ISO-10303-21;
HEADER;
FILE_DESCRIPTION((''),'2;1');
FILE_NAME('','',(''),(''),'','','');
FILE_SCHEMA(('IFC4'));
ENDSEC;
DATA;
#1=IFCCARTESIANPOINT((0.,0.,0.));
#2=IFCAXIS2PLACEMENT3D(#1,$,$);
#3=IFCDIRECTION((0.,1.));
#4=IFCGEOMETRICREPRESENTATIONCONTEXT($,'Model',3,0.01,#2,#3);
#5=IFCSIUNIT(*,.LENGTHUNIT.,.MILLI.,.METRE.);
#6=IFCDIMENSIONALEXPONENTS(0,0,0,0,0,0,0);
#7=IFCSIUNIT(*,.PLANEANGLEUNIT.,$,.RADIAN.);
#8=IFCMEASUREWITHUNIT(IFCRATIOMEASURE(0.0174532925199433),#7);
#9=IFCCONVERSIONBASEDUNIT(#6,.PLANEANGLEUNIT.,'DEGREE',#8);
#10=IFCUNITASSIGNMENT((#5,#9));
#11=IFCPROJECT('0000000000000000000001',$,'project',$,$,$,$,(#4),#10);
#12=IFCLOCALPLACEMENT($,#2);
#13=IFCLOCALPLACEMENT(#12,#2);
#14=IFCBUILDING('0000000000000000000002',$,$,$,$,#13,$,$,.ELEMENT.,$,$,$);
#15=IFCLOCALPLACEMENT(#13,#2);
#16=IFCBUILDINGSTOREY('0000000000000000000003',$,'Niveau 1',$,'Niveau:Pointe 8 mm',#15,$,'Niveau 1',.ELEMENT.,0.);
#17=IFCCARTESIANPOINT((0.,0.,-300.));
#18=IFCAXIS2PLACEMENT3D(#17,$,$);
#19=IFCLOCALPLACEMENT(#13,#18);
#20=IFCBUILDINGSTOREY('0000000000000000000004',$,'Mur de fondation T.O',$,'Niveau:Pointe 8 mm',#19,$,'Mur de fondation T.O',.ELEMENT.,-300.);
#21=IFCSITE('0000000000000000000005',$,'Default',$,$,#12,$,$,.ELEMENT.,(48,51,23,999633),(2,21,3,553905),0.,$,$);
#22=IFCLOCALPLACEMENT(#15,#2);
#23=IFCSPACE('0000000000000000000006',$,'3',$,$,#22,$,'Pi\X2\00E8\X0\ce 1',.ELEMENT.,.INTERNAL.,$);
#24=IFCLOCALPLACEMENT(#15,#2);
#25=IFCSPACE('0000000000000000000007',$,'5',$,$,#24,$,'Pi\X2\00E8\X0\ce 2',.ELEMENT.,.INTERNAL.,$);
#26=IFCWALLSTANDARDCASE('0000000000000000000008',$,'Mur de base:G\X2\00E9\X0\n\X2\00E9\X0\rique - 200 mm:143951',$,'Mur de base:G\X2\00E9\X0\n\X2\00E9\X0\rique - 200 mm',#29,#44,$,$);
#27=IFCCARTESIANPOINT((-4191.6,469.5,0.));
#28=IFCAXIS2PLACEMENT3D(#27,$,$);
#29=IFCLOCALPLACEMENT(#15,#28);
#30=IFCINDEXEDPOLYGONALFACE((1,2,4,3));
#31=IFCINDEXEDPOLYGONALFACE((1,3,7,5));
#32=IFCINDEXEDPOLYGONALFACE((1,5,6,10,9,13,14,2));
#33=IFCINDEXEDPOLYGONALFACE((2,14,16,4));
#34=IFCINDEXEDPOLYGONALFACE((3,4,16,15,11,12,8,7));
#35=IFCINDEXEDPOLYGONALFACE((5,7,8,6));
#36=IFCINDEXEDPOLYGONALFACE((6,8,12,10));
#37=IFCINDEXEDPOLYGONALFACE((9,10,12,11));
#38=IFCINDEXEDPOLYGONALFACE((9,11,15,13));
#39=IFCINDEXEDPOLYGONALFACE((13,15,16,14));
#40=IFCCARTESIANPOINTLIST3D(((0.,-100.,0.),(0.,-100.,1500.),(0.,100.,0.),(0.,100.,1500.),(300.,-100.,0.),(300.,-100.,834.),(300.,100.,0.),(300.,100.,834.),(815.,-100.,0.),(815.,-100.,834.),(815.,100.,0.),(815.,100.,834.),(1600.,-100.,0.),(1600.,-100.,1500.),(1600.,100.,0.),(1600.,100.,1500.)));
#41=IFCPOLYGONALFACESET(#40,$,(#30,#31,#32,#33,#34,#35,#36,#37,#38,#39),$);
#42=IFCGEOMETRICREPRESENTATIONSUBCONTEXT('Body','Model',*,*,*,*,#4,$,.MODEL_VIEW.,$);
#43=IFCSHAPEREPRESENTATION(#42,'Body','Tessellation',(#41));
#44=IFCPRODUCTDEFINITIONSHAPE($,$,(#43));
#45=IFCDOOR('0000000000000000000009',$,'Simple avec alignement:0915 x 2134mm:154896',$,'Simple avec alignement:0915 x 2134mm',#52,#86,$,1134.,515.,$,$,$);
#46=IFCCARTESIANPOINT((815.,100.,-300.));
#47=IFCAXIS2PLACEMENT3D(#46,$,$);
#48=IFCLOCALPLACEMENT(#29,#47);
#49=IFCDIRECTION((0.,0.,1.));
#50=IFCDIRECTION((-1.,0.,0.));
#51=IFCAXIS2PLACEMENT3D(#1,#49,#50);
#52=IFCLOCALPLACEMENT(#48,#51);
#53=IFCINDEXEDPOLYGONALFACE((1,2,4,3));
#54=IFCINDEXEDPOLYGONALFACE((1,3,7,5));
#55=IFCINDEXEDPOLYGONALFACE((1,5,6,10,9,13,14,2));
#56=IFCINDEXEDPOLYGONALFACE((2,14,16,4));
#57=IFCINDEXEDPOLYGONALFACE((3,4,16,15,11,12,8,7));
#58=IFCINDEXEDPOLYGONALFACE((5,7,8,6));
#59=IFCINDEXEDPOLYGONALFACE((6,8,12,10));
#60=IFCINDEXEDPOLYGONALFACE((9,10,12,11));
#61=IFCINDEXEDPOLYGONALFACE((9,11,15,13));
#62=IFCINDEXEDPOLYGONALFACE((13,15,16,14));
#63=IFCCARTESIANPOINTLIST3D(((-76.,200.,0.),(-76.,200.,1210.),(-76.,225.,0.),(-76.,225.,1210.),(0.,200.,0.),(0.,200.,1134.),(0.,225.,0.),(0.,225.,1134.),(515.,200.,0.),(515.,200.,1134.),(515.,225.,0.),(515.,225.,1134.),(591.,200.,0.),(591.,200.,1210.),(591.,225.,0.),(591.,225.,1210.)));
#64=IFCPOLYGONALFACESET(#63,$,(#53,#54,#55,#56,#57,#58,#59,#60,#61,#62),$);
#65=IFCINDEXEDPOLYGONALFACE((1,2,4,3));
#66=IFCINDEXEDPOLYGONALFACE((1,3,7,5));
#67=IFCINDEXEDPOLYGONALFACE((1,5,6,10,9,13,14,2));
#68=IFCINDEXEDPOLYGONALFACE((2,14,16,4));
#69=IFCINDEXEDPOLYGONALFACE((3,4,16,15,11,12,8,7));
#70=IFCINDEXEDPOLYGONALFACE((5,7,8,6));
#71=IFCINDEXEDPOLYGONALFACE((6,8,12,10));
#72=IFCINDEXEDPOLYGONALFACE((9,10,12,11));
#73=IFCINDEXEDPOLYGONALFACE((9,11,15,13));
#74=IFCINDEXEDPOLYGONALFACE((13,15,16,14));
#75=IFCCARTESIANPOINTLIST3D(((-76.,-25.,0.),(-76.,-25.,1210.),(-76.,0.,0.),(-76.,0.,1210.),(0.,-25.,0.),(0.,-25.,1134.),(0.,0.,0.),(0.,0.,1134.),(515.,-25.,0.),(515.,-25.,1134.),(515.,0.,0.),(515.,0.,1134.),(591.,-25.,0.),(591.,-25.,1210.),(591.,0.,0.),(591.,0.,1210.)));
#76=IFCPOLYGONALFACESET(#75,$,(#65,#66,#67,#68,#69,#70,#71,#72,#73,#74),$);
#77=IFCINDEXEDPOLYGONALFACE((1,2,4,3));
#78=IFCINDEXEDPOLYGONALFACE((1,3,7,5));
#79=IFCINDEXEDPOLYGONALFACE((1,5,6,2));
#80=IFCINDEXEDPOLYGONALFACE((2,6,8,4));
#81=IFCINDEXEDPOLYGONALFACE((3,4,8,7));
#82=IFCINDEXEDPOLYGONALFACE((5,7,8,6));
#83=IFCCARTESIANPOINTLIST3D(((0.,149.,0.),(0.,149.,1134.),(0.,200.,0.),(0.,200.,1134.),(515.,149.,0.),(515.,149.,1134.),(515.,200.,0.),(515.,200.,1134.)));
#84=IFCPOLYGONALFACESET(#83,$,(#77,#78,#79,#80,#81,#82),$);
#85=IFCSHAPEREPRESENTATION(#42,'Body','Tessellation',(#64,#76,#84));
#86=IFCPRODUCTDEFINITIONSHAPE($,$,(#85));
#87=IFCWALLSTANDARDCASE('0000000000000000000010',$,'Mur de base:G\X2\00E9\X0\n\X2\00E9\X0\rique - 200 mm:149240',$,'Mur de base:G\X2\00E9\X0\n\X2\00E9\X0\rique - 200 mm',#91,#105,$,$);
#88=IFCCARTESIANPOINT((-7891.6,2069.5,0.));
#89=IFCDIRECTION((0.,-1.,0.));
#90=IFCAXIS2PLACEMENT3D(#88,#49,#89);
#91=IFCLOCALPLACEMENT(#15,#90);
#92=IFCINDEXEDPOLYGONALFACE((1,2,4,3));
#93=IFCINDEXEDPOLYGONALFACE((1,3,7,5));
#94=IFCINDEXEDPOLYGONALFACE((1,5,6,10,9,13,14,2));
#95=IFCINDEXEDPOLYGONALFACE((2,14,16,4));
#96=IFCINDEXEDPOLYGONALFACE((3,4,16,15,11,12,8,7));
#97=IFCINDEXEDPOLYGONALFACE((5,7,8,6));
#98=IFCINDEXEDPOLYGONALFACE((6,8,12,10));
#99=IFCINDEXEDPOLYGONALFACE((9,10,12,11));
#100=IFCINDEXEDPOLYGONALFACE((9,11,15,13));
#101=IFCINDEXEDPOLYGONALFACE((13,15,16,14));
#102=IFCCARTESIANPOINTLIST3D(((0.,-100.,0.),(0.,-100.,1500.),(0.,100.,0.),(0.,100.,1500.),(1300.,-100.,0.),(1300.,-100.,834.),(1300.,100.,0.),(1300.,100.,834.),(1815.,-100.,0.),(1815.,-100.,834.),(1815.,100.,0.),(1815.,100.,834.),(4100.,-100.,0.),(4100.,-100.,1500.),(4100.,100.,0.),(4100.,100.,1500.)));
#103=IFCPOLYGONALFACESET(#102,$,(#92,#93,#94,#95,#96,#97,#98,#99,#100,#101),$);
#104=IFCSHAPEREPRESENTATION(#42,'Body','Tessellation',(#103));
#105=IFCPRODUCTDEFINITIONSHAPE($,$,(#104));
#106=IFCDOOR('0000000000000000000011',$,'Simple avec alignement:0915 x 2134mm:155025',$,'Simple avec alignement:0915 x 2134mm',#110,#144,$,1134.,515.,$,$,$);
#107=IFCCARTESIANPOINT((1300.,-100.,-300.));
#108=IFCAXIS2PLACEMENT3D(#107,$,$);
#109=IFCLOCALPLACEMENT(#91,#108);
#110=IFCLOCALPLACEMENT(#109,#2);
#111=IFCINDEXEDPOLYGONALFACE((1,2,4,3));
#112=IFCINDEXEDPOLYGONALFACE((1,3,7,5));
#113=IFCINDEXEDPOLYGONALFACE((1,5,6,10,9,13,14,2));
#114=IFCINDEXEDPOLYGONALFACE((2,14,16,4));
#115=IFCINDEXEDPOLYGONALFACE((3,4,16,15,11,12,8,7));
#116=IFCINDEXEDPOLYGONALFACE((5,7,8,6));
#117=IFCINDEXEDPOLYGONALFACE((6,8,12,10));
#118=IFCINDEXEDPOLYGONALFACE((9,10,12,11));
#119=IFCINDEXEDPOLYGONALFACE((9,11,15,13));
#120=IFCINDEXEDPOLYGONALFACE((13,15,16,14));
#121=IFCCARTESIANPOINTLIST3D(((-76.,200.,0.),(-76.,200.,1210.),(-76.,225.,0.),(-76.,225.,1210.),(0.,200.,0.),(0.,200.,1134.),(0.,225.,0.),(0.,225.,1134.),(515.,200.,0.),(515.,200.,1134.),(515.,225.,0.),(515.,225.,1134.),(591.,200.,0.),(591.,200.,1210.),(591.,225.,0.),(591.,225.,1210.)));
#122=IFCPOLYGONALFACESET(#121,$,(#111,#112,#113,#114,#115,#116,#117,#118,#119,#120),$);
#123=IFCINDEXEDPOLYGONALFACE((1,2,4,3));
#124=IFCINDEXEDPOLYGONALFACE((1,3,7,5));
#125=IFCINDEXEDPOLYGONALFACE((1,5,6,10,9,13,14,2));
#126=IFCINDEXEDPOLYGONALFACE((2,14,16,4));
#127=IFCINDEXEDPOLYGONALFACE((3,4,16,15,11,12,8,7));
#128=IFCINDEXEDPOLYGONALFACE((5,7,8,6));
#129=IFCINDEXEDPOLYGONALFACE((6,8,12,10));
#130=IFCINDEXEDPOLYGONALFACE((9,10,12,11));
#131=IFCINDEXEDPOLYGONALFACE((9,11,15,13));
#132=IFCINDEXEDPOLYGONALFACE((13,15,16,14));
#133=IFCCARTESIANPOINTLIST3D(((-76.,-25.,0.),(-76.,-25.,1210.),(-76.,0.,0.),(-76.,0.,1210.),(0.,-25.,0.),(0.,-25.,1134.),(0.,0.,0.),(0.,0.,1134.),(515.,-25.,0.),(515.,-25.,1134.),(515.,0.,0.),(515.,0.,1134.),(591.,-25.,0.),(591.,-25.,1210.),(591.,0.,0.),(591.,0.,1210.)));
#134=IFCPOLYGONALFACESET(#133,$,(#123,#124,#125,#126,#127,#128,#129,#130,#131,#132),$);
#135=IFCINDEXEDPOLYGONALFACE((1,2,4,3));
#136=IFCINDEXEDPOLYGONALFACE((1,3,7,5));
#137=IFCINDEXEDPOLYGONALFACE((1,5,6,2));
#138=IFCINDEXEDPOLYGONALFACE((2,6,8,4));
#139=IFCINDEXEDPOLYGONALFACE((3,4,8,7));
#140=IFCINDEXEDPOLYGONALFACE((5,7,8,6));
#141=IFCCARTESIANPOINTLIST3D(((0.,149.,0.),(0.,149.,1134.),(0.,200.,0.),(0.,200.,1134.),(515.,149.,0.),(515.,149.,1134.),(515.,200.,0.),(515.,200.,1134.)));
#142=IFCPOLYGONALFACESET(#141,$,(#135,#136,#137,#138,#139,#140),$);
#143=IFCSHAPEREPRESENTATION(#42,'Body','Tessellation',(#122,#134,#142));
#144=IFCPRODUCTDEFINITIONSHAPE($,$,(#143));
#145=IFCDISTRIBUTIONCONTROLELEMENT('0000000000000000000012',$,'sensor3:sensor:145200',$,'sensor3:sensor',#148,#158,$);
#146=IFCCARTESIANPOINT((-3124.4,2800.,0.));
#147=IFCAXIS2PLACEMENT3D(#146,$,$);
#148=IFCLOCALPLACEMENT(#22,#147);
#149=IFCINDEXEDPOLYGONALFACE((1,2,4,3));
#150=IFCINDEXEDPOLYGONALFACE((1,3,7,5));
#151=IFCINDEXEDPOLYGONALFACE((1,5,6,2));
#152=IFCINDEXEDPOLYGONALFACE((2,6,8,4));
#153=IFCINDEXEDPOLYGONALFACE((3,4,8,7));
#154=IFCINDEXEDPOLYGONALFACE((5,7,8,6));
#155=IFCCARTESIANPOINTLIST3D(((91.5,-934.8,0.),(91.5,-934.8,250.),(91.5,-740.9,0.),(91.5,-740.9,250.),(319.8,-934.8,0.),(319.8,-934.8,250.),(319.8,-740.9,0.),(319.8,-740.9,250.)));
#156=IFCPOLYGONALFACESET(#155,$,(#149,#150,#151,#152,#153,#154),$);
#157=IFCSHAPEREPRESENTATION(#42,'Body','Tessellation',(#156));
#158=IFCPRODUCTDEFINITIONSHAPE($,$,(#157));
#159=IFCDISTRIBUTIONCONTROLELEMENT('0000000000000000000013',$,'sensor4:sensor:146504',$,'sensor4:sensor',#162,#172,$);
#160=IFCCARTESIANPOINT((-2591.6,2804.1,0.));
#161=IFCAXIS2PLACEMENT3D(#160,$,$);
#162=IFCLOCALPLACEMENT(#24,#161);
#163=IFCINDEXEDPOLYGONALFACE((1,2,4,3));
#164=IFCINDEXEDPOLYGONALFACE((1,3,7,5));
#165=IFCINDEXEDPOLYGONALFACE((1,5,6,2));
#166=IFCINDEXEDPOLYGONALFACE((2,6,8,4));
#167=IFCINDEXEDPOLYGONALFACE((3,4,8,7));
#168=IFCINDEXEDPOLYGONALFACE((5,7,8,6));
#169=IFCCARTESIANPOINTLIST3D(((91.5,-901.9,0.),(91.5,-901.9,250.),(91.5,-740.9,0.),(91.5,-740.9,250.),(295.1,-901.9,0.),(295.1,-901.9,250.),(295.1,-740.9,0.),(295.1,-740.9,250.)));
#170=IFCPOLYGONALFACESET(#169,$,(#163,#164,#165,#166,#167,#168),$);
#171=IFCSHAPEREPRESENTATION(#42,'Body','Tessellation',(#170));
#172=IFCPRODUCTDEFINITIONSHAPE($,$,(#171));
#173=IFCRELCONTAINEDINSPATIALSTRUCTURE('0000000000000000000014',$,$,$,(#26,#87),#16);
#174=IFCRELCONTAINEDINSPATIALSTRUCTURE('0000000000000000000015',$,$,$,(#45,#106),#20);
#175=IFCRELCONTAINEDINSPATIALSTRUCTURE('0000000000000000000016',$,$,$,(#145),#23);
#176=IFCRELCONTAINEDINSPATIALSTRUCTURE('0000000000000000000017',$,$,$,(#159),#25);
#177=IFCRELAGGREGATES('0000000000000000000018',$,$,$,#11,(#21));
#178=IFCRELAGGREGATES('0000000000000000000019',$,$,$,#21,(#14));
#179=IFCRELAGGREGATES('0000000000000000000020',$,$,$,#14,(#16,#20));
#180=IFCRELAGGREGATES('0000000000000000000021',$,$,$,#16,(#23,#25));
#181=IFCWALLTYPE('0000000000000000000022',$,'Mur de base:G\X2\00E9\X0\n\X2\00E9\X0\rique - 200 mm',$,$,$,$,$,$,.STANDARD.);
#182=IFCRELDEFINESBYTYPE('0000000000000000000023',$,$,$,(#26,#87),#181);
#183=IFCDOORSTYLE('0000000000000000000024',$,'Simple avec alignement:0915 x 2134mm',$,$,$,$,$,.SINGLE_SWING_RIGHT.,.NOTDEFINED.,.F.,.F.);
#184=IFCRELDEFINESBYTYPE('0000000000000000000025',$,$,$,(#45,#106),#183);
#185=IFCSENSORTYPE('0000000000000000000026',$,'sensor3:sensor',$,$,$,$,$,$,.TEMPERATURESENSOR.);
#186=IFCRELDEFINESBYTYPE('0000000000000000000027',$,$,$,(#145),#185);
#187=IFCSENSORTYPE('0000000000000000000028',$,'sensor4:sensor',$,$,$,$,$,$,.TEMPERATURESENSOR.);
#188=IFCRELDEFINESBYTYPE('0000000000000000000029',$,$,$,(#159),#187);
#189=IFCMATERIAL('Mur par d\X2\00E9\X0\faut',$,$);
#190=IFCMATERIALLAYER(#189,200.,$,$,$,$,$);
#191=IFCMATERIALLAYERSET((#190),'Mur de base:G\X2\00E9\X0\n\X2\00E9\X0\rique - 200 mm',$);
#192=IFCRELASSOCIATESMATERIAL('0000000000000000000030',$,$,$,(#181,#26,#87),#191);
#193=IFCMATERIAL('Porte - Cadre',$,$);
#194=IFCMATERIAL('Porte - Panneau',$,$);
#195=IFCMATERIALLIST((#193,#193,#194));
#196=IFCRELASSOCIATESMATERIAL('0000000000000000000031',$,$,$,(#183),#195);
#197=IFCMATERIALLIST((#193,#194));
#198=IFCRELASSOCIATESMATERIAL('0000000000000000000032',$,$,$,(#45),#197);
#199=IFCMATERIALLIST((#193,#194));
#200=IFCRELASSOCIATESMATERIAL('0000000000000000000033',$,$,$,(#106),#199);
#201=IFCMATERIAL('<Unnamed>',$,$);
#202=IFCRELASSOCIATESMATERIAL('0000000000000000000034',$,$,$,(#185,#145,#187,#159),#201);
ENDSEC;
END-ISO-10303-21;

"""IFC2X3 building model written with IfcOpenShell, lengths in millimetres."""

from ifc_helpers import new_model, entity, si_unit, converted_unit, direction, frame, frame_2d, origin, origin_2d_with_axis, place, context, subcontext, project, spatial, polyline, rectangle, outline, extrude, source, transform, mapped, material, material_list, layer, layer_set, layer_usage, type_object, type_shapes, element, fill, save


model = new_model("IFC2X3")

# Units and contexts
model_context = context("Model", 3, precision=0.01, world=origin(), true_north=direction((0.0, 1.0)))
body_context = subcontext(model_context, "Body", "Model", "MODEL_VIEW")
ifc_project = project(units=[si_unit("LENGTHUNIT", "METRE", prefix="MILLI"), converted_unit("PLANEANGLEUNIT", "DEGREE", entity("IfcRatioMeasure", 0.0174532925199433), si_unit("PLANEANGLEUNIT", "RADIAN"), dimensions=[0, 0, 0, 0, 0, 0, 0])], contexts=[model_context])

# Site, building, storey
site_placement = place(None, origin())
site = spatial("IfcSite", under=ifc_project, at=site_placement, Name="Default", CompositionType="ELEMENT", RefLatitude=(48, 51, 23, 999633), RefLongitude=(2, 21, 3, 553905), RefElevation=0.0)
building_placement = place(site_placement, origin())
building = spatial("IfcBuilding", under=site, at=building_placement, CompositionType="ELEMENT")
storey_1_placement = place(building_placement, origin())
storey_1 = spatial("IfcBuildingStorey", under=building, at=storey_1_placement, Name="Niveau 1", ObjectType="Niveau:Pointe 8 mm", LongName="Niveau 1", CompositionType="ELEMENT", Elevation=0.0)

# Shared definitions
ifc_material_1 = material(Name="Mur par défaut")
ifc_layer_1 = layer(ifc_material_1, 200.0)
ifc_layer_set_1 = layer_set([ifc_layer_1], Name="Mur de base:Générique - 200 mm")
wall_type = type_object("IfcWallType", Name="Mur de base:Générique - 200 mm", PredefinedType="STANDARD", material=ifc_layer_set_1)
ifc_material_2 = material(Name="Porte - Cadre")
ifc_material_3 = material(Name="Porte - Panneau")
ifc_material_list_1 = material_list([ifc_material_2, ifc_material_2, ifc_material_3])
door_style = type_object("IfcDoorStyle", Name="Simple avec alignement:0915 x 2134mm", ConstructionType="NOTDEFINED", OperationType="SINGLE_SWING_RIGHT", ParameterTakesPrecedence=False, Sizeable=False, material=ifc_material_list_1)
shared_shape_1 = source(origin(), body_context, "Body", "SweptSolid", [
    extrude(outline(polyline([(-333.5, -624.0), (333.5, -624.0), (333.5, 586.0), (257.5, 586.0), (257.5, -548.0), (-257.5, -548.0), (-257.5, 586.0), (-333.5, 586.0), (-333.5, -624.0)])), frame((257.5, 200.0, 586.0), z_axis=(0.0, 1.0, 0.0), x_axis=(1.0, 0.0, 0.0)), (0.0, 0.0, 1.0), 25.0),
    extrude(outline(polyline([(-624.0, -333.5), (586.0, -333.5), (586.0, -257.5), (-548.0, -257.5), (-548.0, 257.5), (586.0, 257.5), (586.0, 333.5), (-624.0, 333.5), (-624.0, -333.5)])), frame((257.5, -25.0, 586.0), z_axis=(0.0, 1.0, 0.0), x_axis=(0.0, 0.0, -1.0)), (0.0, 0.0, 1.0), 25.0),
    extrude(rectangle(XDim=51.0, YDim=515.0, at=frame_2d((0.0, 0.0), x_axis=(1.0, 0.0))), frame((257.5, 174.5, 0.0), z_axis=(0.0, 0.0, 1.0), x_axis=(0.0, 1.0, 0.0)), (0.0, 0.0, 1.0), 1134.0),
])
type_shapes(door_style, [shared_shape_1])

# Shared definitions
storey_2_placement = place(building_placement, frame((0.0, 0.0, -300.0)))
storey_2 = spatial("IfcBuildingStorey", under=building, at=storey_2_placement, Name="Mur de fondation T.O", ObjectType="Niveau:Pointe 8 mm", LongName="Mur de fondation T.O", CompositionType="ELEMENT", Elevation=-300.0)

# Wall, opening, door
ifc_layer_usage_1 = layer_usage(ifc_layer_set_1, "AXIS2", "POSITIVE", -100.0)
wall_1_placement = place(storey_1_placement, frame((-4191.6, 469.5, 0.0)))
wall_1 = element("IfcWallStandardCase", 1, at=wall_1_placement, inside=storey_1, type_object=wall_type, material=ifc_layer_usage_1, Name="Mur de base:Générique - 200 mm:143951", ObjectType="Mur de base:Générique - 200 mm", context=body_context, shape_type="SweptSolid", body=[
    extrude(rectangle(XDim=1600.0, YDim=200.0, at=frame_2d((800.0, 0.0), x_axis=(-1.0, 0.0))), origin(), (0.0, 0.0, 1.0), 1500.0),
])
opening_1_placement = place(wall_1_placement, frame((815.0, 100.0, -300.0)))
opening_1 = element("IfcOpeningElement", 2, at=opening_1_placement, cuts=wall_1, ObjectType="Opening", context=body_context, shape_type="SweptSolid", body=[
    extrude(rectangle(XDim=515.0, YDim=1134.0, at=frame_2d((567.0, 257.5), x_axis=(0.0, 1.0))), frame((0.0, 0.0, 0.0), z_axis=(0.0, -1.0, 0.0), x_axis=(0.0, 0.0, 1.0)), (0.0, 0.0, 1.0), 200.0),
])
ifc_material_list_2 = material_list([ifc_material_2, ifc_material_3])
door_1_placement = place(opening_1_placement, frame((0.0, 0.0, 0.0), z_axis=(0.0, 0.0, 1.0), x_axis=(-1.0, 0.0, 0.0)))
door_1 = element("IfcDoor", 3, at=door_1_placement, inside=storey_2, type_object=door_style, material=ifc_material_list_2, Name="Simple avec alignement:0915 x 2134mm:154896", ObjectType="Simple avec alignement:0915 x 2134mm", OverallHeight=1134.0, OverallWidth=515.0, context=body_context, shape_type="MappedRepresentation", body=[
    mapped(shared_shape_1, transform((0.0, 0.0, 0.0), scale=1.0)),
])
fill(opening_1, door_1)

# Wall, opening, door
ifc_layer_usage_2 = layer_usage(ifc_layer_set_1, "AXIS2", "NEGATIVE", 100.0)
wall_2_placement = place(storey_1_placement, frame((-7891.6, 2069.5, 0.0), z_axis=(0.0, 0.0, 1.0), x_axis=(0.0, -1.0, 0.0)))
wall_2 = element("IfcWallStandardCase", 4, at=wall_2_placement, inside=storey_1, type_object=wall_type, material=ifc_layer_usage_2, Name="Mur de base:Générique - 200 mm:149240", ObjectType="Mur de base:Générique - 200 mm", context=body_context, shape_type="SweptSolid", body=[
    extrude(rectangle(XDim=4100.0, YDim=200.0, at=frame_2d((2050.0, 0.0), x_axis=(-1.0, 0.0))), origin(), (0.0, 0.0, 1.0), 1500.0),
])
opening_2_placement = place(wall_2_placement, frame((1300.0, -100.0, -300.0)))
opening_2 = element("IfcOpeningElement", 5, at=opening_2_placement, cuts=wall_2, ObjectType="Opening", context=body_context, shape_type="SweptSolid", body=[
    extrude(rectangle(XDim=515.0, YDim=1134.0, at=frame_2d((567.0, 257.5), x_axis=(0.0, 1.0))), frame((0.0, 0.0, 0.0), z_axis=(0.0, 1.0, 0.0), x_axis=(0.0, 0.0, 1.0)), (0.0, 0.0, 1.0), 200.0),
])
ifc_material_list_3 = material_list([ifc_material_2, ifc_material_3])
door_2_placement = place(opening_2_placement, origin())
door_2 = element("IfcDoor", 6, at=door_2_placement, inside=storey_2, type_object=door_style, material=ifc_material_list_3, Name="Simple avec alignement:0915 x 2134mm:155025", ObjectType="Simple avec alignement:0915 x 2134mm", OverallHeight=1134.0, OverallWidth=515.0, context=body_context, shape_type="MappedRepresentation", body=[
    mapped(shared_shape_1, transform((0.0, 0.0, 0.0), scale=1.0)),
])
fill(opening_2, door_2)

# Shared definitions
space_1_placement = place(storey_1_placement, origin())
space_1 = spatial("IfcSpace", under=storey_1, at=space_1_placement, Name="3", LongName="Pièce 1", CompositionType="ELEMENT", InteriorOrExteriorSpace="INTERNAL")

# Distribution control element
ifc_material_4 = material(Name="<Unnamed>")
sensor_type_1 = type_object("IfcSensorType", Name="sensor3:sensor", PredefinedType="TEMPERATURESENSOR", material=ifc_material_4)
shared_shape_2 = source(origin(), body_context, "Body", "SweptSolid", [
    extrude(rectangle(XDim=228.4, YDim=193.9, at=origin_2d_with_axis()), frame((205.7, -837.9, 0.0), z_axis=(0.0, 0.0, 1.0), x_axis=(-1.0, 0.0, 0.0)), (0.0, 0.0, 1.0), 250.0),
])
type_shapes(sensor_type_1, [shared_shape_2])
distribution_control_element_1_placement = place(space_1_placement, frame((-3124.4, 2800.0, 0.0)))
element("IfcDistributionControlElement", 7, at=distribution_control_element_1_placement, inside=space_1, type_object=sensor_type_1, material=ifc_material_4, Name="sensor3:sensor:145200", ObjectType="sensor3:sensor", context=body_context, shape_type="MappedRepresentation", body=[
    mapped(shared_shape_2, transform((0.0, 0.0, 0.0), scale=1.0)),
])

# Shared definitions
space_2_placement = place(storey_1_placement, origin())
space_2 = spatial("IfcSpace", under=storey_1, at=space_2_placement, Name="5", LongName="Pièce 2", CompositionType="ELEMENT", InteriorOrExteriorSpace="INTERNAL")

# Distribution control element
sensor_type_2 = type_object("IfcSensorType", Name="sensor4:sensor", PredefinedType="TEMPERATURESENSOR", material=ifc_material_4)
shared_shape_3 = source(origin(), body_context, "Body", "SweptSolid", [
    extrude(rectangle(XDim=203.6, YDim=161.0, at=origin_2d_with_axis()), frame((193.3, -821.4, 0.0), z_axis=(0.0, 0.0, 1.0), x_axis=(-1.0, 0.0, 0.0)), (0.0, 0.0, 1.0), 250.0),
])
type_shapes(sensor_type_2, [shared_shape_3])
distribution_control_element_2_placement = place(space_2_placement, frame((-2591.6, 2804.1, 0.0)))
element("IfcDistributionControlElement", 8, at=distribution_control_element_2_placement, inside=space_2, type_object=sensor_type_2, material=ifc_material_4, Name="sensor4:sensor:146504", ObjectType="sensor4:sensor", context=body_context, shape_type="MappedRepresentation", body=[
    mapped(shared_shape_3, transform((0.0, 0.0, 0.0), scale=1.0)),
])

save(model, "model.ifc")
